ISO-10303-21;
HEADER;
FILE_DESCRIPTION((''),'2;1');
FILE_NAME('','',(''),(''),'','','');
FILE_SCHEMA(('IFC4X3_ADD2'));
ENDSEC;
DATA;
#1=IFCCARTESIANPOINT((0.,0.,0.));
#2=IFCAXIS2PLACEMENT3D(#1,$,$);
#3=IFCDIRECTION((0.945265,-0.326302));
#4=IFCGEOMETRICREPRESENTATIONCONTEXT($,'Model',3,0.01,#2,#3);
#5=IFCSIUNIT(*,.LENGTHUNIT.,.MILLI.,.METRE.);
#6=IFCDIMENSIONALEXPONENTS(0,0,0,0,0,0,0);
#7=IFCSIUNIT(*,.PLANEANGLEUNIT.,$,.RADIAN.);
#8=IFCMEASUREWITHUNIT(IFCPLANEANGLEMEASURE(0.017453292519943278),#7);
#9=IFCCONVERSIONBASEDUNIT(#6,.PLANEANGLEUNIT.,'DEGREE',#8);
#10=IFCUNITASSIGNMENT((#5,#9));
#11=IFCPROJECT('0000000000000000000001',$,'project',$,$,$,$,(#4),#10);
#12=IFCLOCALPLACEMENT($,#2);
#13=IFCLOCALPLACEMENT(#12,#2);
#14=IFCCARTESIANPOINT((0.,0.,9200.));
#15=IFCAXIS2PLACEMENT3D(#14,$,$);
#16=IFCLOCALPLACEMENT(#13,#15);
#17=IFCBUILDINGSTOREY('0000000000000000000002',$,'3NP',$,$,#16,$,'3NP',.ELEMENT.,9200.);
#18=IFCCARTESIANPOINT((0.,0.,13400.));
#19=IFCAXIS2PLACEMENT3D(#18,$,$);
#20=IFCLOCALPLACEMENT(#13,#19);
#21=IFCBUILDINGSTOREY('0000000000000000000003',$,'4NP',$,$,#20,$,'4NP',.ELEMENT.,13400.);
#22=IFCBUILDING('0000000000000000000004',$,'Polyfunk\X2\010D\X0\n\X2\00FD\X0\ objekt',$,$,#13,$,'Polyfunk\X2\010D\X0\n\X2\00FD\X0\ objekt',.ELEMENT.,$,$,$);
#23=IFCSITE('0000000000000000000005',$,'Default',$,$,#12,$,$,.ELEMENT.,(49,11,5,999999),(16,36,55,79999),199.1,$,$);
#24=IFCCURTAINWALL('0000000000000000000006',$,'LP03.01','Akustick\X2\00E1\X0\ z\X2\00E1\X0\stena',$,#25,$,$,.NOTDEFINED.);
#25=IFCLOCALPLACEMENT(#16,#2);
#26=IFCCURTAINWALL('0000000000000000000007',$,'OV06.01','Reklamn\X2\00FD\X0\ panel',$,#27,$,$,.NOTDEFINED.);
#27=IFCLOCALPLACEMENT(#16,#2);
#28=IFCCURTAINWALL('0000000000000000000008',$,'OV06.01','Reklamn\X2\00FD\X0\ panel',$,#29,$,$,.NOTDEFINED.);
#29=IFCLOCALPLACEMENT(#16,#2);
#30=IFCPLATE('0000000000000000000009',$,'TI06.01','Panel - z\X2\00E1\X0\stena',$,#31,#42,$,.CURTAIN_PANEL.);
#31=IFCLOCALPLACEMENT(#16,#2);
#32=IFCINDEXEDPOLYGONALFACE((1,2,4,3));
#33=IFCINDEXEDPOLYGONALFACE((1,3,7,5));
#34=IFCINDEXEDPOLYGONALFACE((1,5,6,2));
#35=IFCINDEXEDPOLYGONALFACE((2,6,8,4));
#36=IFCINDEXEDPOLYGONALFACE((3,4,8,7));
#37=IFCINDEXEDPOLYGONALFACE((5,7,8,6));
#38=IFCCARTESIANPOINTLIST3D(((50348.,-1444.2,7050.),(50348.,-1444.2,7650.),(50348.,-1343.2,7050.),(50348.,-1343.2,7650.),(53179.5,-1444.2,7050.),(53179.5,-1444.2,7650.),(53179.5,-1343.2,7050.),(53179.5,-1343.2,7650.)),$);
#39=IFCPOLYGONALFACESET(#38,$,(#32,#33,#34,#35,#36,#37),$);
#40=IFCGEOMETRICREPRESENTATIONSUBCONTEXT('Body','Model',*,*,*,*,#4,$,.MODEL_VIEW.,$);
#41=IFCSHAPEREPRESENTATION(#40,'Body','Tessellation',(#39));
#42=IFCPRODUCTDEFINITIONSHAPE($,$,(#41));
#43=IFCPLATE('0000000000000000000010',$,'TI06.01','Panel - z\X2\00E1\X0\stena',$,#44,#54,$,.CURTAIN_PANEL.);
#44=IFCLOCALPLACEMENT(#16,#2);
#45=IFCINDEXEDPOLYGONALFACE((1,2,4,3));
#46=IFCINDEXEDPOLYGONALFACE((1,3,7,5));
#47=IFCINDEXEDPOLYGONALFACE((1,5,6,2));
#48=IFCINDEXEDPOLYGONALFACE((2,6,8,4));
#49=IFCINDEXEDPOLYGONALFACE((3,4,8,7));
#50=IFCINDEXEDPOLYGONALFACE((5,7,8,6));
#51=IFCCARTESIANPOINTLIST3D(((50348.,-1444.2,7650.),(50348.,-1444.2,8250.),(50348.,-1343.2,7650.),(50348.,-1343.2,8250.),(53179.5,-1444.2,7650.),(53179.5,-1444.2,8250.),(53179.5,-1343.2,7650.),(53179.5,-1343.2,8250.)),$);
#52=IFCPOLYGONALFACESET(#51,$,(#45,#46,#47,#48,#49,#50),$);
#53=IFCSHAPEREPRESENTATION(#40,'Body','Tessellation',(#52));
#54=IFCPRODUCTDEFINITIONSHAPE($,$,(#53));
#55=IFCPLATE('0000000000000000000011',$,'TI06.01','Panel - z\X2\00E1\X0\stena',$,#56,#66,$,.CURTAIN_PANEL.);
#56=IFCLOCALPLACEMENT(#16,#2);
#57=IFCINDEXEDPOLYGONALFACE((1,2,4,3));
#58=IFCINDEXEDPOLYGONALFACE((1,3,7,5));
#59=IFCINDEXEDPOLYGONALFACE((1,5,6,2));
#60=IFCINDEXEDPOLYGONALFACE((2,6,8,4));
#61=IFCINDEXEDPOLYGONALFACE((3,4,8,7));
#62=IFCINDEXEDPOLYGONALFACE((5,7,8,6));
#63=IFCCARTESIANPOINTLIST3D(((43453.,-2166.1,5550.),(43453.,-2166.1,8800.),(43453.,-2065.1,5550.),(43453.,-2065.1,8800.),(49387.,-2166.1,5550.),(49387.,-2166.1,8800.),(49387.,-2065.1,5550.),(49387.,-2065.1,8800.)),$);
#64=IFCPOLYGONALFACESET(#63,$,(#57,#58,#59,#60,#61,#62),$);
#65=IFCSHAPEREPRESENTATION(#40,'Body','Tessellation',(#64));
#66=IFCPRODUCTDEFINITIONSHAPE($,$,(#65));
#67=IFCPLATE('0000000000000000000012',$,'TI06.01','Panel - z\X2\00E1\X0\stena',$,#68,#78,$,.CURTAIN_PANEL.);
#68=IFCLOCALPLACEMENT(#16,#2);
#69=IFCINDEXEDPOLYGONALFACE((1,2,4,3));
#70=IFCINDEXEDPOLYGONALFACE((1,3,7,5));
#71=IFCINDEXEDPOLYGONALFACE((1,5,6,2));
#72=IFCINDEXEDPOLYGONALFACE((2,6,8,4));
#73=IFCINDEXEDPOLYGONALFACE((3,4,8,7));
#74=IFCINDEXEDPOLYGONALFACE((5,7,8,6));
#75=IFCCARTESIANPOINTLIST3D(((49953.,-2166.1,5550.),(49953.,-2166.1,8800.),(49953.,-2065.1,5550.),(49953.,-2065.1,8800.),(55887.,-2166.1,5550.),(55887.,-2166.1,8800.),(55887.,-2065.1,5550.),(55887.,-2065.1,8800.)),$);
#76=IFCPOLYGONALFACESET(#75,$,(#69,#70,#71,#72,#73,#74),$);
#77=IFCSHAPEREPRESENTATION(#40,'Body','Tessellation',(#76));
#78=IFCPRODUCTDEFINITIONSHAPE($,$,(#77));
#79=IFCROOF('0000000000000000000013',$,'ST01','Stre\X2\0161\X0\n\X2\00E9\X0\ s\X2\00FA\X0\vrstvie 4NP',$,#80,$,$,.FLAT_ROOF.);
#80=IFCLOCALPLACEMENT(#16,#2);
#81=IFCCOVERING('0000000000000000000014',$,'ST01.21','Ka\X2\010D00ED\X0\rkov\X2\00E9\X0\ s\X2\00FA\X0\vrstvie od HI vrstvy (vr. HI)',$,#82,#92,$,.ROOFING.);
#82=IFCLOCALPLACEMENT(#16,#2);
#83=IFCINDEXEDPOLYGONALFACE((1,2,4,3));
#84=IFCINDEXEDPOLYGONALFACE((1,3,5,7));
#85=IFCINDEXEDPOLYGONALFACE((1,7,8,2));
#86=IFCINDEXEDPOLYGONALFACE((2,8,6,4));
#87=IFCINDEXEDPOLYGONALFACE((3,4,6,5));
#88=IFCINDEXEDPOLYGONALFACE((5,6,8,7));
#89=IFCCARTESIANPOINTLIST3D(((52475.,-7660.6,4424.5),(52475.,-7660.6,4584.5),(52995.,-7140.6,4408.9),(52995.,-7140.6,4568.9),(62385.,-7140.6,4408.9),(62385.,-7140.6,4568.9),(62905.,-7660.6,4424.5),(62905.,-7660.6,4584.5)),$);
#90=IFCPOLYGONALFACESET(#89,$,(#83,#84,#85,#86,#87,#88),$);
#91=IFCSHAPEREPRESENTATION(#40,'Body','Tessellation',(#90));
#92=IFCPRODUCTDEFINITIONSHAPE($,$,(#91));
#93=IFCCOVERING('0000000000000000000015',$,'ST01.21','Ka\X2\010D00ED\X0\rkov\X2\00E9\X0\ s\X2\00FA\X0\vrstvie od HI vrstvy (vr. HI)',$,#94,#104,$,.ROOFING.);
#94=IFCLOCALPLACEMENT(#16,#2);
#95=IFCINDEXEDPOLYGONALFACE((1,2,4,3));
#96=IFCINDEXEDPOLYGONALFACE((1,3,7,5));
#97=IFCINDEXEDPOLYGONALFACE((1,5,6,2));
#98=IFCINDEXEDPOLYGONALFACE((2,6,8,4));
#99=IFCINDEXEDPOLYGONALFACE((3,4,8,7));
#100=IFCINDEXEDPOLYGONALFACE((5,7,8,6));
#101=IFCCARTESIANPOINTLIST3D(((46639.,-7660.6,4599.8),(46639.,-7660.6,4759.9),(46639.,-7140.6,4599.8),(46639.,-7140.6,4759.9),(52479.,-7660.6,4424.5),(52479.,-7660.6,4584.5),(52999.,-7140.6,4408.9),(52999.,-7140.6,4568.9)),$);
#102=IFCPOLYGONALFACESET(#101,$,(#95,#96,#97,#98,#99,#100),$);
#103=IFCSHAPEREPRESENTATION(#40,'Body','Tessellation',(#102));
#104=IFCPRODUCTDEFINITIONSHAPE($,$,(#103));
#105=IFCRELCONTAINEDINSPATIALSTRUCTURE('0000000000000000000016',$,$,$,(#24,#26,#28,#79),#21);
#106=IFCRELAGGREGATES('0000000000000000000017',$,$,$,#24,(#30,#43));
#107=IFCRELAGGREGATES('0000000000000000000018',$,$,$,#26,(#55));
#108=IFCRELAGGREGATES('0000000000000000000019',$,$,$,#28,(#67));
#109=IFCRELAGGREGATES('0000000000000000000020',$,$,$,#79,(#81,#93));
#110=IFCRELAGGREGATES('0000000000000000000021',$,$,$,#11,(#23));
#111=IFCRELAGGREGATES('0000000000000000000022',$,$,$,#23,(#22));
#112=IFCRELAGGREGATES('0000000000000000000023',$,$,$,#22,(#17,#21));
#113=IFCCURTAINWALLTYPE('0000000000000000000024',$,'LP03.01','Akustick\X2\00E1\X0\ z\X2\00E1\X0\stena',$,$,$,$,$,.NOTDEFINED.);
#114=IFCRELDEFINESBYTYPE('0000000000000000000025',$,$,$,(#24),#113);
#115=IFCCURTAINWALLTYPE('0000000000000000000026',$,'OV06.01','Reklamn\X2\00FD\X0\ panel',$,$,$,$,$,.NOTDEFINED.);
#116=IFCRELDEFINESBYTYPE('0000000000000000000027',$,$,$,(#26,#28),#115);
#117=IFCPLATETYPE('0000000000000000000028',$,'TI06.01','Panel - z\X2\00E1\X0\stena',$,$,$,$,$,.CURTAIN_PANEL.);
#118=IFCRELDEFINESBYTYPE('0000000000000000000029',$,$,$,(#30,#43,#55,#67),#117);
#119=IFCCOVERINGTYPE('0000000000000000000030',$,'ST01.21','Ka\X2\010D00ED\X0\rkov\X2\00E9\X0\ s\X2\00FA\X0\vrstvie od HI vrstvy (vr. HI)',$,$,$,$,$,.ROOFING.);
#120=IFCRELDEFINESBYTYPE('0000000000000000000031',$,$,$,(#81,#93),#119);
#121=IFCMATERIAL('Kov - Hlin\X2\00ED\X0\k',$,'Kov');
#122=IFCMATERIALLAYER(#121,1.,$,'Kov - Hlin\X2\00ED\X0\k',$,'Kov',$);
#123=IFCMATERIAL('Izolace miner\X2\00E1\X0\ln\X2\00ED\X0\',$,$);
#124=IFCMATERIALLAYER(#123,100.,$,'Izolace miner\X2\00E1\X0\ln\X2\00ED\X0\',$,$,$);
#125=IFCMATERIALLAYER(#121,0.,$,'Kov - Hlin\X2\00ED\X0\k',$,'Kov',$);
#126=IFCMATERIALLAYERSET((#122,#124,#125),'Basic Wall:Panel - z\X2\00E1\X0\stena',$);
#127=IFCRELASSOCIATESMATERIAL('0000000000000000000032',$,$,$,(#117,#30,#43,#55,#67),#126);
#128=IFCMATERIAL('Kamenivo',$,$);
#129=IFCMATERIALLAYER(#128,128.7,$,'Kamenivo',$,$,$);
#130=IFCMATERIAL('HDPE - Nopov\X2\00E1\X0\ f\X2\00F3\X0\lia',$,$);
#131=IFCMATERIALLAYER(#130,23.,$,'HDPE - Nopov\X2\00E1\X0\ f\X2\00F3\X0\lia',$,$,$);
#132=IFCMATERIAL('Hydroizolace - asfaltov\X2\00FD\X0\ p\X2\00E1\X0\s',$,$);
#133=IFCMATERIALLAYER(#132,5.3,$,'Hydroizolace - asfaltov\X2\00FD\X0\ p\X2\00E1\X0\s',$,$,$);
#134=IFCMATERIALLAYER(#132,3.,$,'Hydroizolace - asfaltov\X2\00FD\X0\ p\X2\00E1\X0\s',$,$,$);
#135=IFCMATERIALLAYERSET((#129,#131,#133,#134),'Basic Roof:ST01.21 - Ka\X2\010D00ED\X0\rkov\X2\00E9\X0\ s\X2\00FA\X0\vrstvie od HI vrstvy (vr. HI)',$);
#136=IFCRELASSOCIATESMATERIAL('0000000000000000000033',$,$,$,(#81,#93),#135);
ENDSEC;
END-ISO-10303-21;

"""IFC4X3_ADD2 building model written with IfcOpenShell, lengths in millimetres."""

from ifc_helpers import new_model, entity, si_unit, converted_unit, direction, frame, frame_2d, origin, place, context, subcontext, project, spatial, polyline, rectangle, outline, extrude, material, layer, layer_set, layer_usage, type_object, element, aggregate, save


model = new_model("IFC4X3_ADD2")

# Units and contexts
model_context = context("Model", 3, precision=0.01, world=origin(), true_north=direction((0.945265, -0.326302)))
body_context = subcontext(model_context, "Body", "Model", "MODEL_VIEW")
ifc_project = project(units=[si_unit("LENGTHUNIT", "METRE", prefix="MILLI"), converted_unit("PLANEANGLEUNIT", "DEGREE", entity("IfcPlaneAngleMeasure", 0.017453292519943278), si_unit("PLANEANGLEUNIT", "RADIAN"), dimensions=[0, 0, 0, 0, 0, 0, 0])], contexts=[model_context])

# Site, building, storey
site_placement = place(None, origin())
site = spatial("IfcSite", under=ifc_project, at=site_placement, Name="Default", CompositionType="ELEMENT", RefLatitude=(49, 11, 5, 999999), RefLongitude=(16, 36, 55, 79999), RefElevation=199.1)
building_placement = place(site_placement, origin())
building = spatial("IfcBuilding", under=site, at=building_placement, Name="Polyfunkčný objekt", LongName="Polyfunkčný objekt", CompositionType="ELEMENT")
storey_1_placement = place(building_placement, frame((0.0, 0.0, 9200.0)))
storey_1 = spatial("IfcBuildingStorey", under=building, at=storey_1_placement, Name="3NP", LongName="3NP", CompositionType="ELEMENT", Elevation=9200.0)

# Shared definitions
storey_2_placement = place(building_placement, frame((0.0, 0.0, 13400.0)))
storey_2 = spatial("IfcBuildingStorey", under=building, at=storey_2_placement, Name="4NP", LongName="4NP", CompositionType="ELEMENT", Elevation=13400.0)

# Curtain wall
curtain_wall_type_1 = type_object("IfcCurtainWallType", Name="LP03.01", Description="Akustická zástena", PredefinedType="NOTDEFINED")
curtain_wall_1_placement = place(storey_2_placement, frame((0.0, 0.0, -13400.0)))
curtain_wall_1 = element("IfcCurtainWall", 1, at=curtain_wall_1_placement, inside=storey_2, type_object=curtain_wall_type_1, Name="LP03.01", Description="Akustická zástena", PredefinedType="NOTDEFINED")

# Curtain walls
curtain_wall_type_2 = type_object("IfcCurtainWallType", Name="OV06.01", Description="Reklamný panel", PredefinedType="NOTDEFINED")
curtain_wall_2_placement = place(storey_2_placement, frame((0.0, 0.0, -13400.0)))
curtain_wall_2 = element("IfcCurtainWall", 2, at=curtain_wall_2_placement, inside=storey_2, type_object=curtain_wall_type_2, Name="OV06.01", Description="Reklamný panel", PredefinedType="NOTDEFINED")
curtain_wall_3_placement = place(storey_2_placement, frame((0.0, 0.0, -13400.0)))
curtain_wall_3 = element("IfcCurtainWall", 3, at=curtain_wall_3_placement, inside=storey_2, type_object=curtain_wall_type_2, Name="OV06.01", Description="Reklamný panel", PredefinedType="NOTDEFINED")

# Plates
ifc_material_1 = material(Name="Kov - Hliník", Category="Kov")
ifc_layer_1 = layer(ifc_material_1, 1.0, Name="Kov - Hliník", Category="Kov")
ifc_material_2 = material(Name="Izolace minerální")
ifc_layer_2 = layer(ifc_material_2, 100.0, Name="Izolace minerální")
ifc_layer_3 = layer(ifc_material_1, 0.0, Name="Kov - Hliník", Category="Kov")
ifc_layer_set_1 = layer_set([ifc_layer_1, ifc_layer_2, ifc_layer_3], Name="Basic Wall:Panel - zástena")
plate_type = type_object("IfcPlateType", Name="TI06.01", Description="Panel - zástena", PredefinedType="CURTAIN_PANEL", material=ifc_layer_set_1)
ifc_layer_usage_1 = layer_usage(ifc_layer_set_1, "AXIS2", "POSITIVE", -50.5)
plate_1_placement = place(storey_2_placement, frame((50348.0, -1393.7, 2850.0)))
plate_1 = element("IfcPlate", 4, at=plate_1_placement, type_object=plate_type, material=ifc_layer_usage_1, Name="TI06.01", Description="Panel - zástena", PredefinedType="CURTAIN_PANEL", context=body_context, shape_type="SweptSolid", body=[
    extrude(rectangle(XDim=101.0, YDim=2831.5, at=frame_2d((0.0, 0.0), x_axis=(1.0, 0.0))), frame((1415.8, 0.0, 0.0), z_axis=(0.0, 0.0, 1.0), x_axis=(0.0, 1.0, 0.0)), (0.0, 0.0, 1.0), 600.0),
])
ifc_layer_usage_2 = layer_usage(ifc_layer_set_1, "AXIS2", "POSITIVE", -50.5)
plate_2_placement = place(storey_2_placement, frame((50348.0, -1393.7, 3450.0)))
plate_2 = element("IfcPlate", 5, at=plate_2_placement, type_object=plate_type, material=ifc_layer_usage_2, Name="TI06.01", Description="Panel - zástena", PredefinedType="CURTAIN_PANEL", context=body_context, shape_type="SweptSolid", body=[
    extrude(rectangle(XDim=101.0, YDim=2831.5, at=frame_2d((0.0, 0.0), x_axis=(1.0, 0.0))), frame((1415.8, 0.0, 0.0), z_axis=(0.0, 0.0, 1.0), x_axis=(0.0, 1.0, 0.0)), (0.0, 0.0, 1.0), 600.0),
])
aggregate(curtain_wall_1, [plate_1, plate_2])
ifc_layer_usage_3 = layer_usage(ifc_layer_set_1, "AXIS2", "NEGATIVE", 50.5)
plate_3_placement = place(storey_2_placement, frame((43453.0, -2115.6, 1350.0)))
plate_3 = element("IfcPlate", 6, at=plate_3_placement, type_object=plate_type, material=ifc_layer_usage_3, Name="TI06.01", Description="Panel - zástena", PredefinedType="CURTAIN_PANEL", context=body_context, shape_type="SweptSolid", body=[
    extrude(rectangle(XDim=101.0, YDim=5934.0, at=frame_2d((0.0, 0.0), x_axis=(1.0, 0.0))), frame((2967.0, 0.0, 0.0), z_axis=(0.0, 0.0, 1.0), x_axis=(0.0, 1.0, 0.0)), (0.0, 0.0, 1.0), 3250.0),
])
aggregate(curtain_wall_2, [plate_3])
ifc_layer_usage_4 = layer_usage(ifc_layer_set_1, "AXIS2", "NEGATIVE", 50.5)
plate_4_placement = place(storey_2_placement, frame((49953.0, -2115.6, 1350.0)))
plate_4 = element("IfcPlate", 7, at=plate_4_placement, type_object=plate_type, material=ifc_layer_usage_4, Name="TI06.01", Description="Panel - zástena", PredefinedType="CURTAIN_PANEL", context=body_context, shape_type="SweptSolid", body=[
    extrude(rectangle(XDim=101.0, YDim=5934.0, at=frame_2d((0.0, 0.0), x_axis=(1.0, 0.0))), frame((2967.0, 0.0, 0.0), z_axis=(0.0, 0.0, 1.0), x_axis=(0.0, 1.0, 0.0)), (0.0, 0.0, 1.0), 3250.0),
])
aggregate(curtain_wall_3, [plate_4])

# Roof, coverings
roof = element("IfcRoof", 8, inside=storey_2, Name="ST01", Description="Strešné súvrstvie 4NP", PredefinedType="FLAT_ROOF")
ifc_material_3 = material(Name="HDPE - Nopová fólia")
ifc_material_4 = material(Name="Hydroizolace - asfaltový pás")
ifc_material_5 = material(Name="Kamenivo")
ifc_layer_4 = layer(ifc_material_5, 128.7, Name="Kamenivo")
ifc_layer_5 = layer(ifc_material_3, 23.0, Name="HDPE - Nopová fólia")
ifc_layer_6 = layer(ifc_material_4, 5.3, Name="Hydroizolace - asfaltový pás")
ifc_layer_7 = layer(ifc_material_4, 3.0, Name="Hydroizolace - asfaltový pás")
ifc_layer_set_2 = layer_set([ifc_layer_4, ifc_layer_5, ifc_layer_6, ifc_layer_7], Name="Basic Roof:ST01.21 - Kačírkové súvrstvie od HI vrstvy (vr. HI)")
covering_type_1 = type_object("IfcCoveringType", Name="ST01.21", Description="Kačírkové súvrstvie od HI vrstvy (vr. HI)", PredefinedType="ROOFING")
placement_1 = place(storey_2_placement, frame((52475.0, -7660.6, 208.9)))
covering_1_placement = place(placement_1, origin())
covering_1 = element("IfcCovering", 9, at=covering_1_placement, type_object=covering_type_1, material=ifc_layer_set_2, Name="ST01.21", Description="Kačírkové súvrstvie od HI vrstvy (vr. HI)", PredefinedType="ROOFING", context=body_context, shape_type="SweptSolid", body=[
    extrude(outline(polyline([(-4695.0, 260.1), (-5215.0, -260.1), (5215.0, -260.1), (4695.0, 260.1), (-4695.0, 260.1)])), frame((5215.0, 260.0, 7.8), z_axis=(0.0, 0.030015, 0.999549), x_axis=(1.0, 0.0, 0.0)), (0.0, -0.030015, 0.999549), 160.1),
])
placement_2 = place(storey_2_placement, frame((46639.0, -7660.6, 208.9)))
covering_2_placement = place(placement_2, origin())
covering_2 = element("IfcCovering", 10, at=covering_2_placement, type_object=covering_type_1, material=ifc_layer_set_2, Name="ST01.21", Description="Kačírkové súvrstvie od HI vrstvy (vr. HI)", PredefinedType="ROOFING", context=body_context, shape_type="SweptSolid", body=[
    extrude(outline(polyline([(3181.4, 260.0), (-3181.4, 260.0), (-3181.4, -260.0), (2661.2, -260.0), (3181.4, 260.0)])), frame((3180.0, 260.0, 95.5), z_axis=(0.030015, 0.0, 0.999549), x_axis=(0.999549, 0.0, -0.030015)), (-0.030015, 0.0, 0.999549), 160.1),
])
aggregate(roof, [covering_1, covering_2])

save(model, "model.ifc")
